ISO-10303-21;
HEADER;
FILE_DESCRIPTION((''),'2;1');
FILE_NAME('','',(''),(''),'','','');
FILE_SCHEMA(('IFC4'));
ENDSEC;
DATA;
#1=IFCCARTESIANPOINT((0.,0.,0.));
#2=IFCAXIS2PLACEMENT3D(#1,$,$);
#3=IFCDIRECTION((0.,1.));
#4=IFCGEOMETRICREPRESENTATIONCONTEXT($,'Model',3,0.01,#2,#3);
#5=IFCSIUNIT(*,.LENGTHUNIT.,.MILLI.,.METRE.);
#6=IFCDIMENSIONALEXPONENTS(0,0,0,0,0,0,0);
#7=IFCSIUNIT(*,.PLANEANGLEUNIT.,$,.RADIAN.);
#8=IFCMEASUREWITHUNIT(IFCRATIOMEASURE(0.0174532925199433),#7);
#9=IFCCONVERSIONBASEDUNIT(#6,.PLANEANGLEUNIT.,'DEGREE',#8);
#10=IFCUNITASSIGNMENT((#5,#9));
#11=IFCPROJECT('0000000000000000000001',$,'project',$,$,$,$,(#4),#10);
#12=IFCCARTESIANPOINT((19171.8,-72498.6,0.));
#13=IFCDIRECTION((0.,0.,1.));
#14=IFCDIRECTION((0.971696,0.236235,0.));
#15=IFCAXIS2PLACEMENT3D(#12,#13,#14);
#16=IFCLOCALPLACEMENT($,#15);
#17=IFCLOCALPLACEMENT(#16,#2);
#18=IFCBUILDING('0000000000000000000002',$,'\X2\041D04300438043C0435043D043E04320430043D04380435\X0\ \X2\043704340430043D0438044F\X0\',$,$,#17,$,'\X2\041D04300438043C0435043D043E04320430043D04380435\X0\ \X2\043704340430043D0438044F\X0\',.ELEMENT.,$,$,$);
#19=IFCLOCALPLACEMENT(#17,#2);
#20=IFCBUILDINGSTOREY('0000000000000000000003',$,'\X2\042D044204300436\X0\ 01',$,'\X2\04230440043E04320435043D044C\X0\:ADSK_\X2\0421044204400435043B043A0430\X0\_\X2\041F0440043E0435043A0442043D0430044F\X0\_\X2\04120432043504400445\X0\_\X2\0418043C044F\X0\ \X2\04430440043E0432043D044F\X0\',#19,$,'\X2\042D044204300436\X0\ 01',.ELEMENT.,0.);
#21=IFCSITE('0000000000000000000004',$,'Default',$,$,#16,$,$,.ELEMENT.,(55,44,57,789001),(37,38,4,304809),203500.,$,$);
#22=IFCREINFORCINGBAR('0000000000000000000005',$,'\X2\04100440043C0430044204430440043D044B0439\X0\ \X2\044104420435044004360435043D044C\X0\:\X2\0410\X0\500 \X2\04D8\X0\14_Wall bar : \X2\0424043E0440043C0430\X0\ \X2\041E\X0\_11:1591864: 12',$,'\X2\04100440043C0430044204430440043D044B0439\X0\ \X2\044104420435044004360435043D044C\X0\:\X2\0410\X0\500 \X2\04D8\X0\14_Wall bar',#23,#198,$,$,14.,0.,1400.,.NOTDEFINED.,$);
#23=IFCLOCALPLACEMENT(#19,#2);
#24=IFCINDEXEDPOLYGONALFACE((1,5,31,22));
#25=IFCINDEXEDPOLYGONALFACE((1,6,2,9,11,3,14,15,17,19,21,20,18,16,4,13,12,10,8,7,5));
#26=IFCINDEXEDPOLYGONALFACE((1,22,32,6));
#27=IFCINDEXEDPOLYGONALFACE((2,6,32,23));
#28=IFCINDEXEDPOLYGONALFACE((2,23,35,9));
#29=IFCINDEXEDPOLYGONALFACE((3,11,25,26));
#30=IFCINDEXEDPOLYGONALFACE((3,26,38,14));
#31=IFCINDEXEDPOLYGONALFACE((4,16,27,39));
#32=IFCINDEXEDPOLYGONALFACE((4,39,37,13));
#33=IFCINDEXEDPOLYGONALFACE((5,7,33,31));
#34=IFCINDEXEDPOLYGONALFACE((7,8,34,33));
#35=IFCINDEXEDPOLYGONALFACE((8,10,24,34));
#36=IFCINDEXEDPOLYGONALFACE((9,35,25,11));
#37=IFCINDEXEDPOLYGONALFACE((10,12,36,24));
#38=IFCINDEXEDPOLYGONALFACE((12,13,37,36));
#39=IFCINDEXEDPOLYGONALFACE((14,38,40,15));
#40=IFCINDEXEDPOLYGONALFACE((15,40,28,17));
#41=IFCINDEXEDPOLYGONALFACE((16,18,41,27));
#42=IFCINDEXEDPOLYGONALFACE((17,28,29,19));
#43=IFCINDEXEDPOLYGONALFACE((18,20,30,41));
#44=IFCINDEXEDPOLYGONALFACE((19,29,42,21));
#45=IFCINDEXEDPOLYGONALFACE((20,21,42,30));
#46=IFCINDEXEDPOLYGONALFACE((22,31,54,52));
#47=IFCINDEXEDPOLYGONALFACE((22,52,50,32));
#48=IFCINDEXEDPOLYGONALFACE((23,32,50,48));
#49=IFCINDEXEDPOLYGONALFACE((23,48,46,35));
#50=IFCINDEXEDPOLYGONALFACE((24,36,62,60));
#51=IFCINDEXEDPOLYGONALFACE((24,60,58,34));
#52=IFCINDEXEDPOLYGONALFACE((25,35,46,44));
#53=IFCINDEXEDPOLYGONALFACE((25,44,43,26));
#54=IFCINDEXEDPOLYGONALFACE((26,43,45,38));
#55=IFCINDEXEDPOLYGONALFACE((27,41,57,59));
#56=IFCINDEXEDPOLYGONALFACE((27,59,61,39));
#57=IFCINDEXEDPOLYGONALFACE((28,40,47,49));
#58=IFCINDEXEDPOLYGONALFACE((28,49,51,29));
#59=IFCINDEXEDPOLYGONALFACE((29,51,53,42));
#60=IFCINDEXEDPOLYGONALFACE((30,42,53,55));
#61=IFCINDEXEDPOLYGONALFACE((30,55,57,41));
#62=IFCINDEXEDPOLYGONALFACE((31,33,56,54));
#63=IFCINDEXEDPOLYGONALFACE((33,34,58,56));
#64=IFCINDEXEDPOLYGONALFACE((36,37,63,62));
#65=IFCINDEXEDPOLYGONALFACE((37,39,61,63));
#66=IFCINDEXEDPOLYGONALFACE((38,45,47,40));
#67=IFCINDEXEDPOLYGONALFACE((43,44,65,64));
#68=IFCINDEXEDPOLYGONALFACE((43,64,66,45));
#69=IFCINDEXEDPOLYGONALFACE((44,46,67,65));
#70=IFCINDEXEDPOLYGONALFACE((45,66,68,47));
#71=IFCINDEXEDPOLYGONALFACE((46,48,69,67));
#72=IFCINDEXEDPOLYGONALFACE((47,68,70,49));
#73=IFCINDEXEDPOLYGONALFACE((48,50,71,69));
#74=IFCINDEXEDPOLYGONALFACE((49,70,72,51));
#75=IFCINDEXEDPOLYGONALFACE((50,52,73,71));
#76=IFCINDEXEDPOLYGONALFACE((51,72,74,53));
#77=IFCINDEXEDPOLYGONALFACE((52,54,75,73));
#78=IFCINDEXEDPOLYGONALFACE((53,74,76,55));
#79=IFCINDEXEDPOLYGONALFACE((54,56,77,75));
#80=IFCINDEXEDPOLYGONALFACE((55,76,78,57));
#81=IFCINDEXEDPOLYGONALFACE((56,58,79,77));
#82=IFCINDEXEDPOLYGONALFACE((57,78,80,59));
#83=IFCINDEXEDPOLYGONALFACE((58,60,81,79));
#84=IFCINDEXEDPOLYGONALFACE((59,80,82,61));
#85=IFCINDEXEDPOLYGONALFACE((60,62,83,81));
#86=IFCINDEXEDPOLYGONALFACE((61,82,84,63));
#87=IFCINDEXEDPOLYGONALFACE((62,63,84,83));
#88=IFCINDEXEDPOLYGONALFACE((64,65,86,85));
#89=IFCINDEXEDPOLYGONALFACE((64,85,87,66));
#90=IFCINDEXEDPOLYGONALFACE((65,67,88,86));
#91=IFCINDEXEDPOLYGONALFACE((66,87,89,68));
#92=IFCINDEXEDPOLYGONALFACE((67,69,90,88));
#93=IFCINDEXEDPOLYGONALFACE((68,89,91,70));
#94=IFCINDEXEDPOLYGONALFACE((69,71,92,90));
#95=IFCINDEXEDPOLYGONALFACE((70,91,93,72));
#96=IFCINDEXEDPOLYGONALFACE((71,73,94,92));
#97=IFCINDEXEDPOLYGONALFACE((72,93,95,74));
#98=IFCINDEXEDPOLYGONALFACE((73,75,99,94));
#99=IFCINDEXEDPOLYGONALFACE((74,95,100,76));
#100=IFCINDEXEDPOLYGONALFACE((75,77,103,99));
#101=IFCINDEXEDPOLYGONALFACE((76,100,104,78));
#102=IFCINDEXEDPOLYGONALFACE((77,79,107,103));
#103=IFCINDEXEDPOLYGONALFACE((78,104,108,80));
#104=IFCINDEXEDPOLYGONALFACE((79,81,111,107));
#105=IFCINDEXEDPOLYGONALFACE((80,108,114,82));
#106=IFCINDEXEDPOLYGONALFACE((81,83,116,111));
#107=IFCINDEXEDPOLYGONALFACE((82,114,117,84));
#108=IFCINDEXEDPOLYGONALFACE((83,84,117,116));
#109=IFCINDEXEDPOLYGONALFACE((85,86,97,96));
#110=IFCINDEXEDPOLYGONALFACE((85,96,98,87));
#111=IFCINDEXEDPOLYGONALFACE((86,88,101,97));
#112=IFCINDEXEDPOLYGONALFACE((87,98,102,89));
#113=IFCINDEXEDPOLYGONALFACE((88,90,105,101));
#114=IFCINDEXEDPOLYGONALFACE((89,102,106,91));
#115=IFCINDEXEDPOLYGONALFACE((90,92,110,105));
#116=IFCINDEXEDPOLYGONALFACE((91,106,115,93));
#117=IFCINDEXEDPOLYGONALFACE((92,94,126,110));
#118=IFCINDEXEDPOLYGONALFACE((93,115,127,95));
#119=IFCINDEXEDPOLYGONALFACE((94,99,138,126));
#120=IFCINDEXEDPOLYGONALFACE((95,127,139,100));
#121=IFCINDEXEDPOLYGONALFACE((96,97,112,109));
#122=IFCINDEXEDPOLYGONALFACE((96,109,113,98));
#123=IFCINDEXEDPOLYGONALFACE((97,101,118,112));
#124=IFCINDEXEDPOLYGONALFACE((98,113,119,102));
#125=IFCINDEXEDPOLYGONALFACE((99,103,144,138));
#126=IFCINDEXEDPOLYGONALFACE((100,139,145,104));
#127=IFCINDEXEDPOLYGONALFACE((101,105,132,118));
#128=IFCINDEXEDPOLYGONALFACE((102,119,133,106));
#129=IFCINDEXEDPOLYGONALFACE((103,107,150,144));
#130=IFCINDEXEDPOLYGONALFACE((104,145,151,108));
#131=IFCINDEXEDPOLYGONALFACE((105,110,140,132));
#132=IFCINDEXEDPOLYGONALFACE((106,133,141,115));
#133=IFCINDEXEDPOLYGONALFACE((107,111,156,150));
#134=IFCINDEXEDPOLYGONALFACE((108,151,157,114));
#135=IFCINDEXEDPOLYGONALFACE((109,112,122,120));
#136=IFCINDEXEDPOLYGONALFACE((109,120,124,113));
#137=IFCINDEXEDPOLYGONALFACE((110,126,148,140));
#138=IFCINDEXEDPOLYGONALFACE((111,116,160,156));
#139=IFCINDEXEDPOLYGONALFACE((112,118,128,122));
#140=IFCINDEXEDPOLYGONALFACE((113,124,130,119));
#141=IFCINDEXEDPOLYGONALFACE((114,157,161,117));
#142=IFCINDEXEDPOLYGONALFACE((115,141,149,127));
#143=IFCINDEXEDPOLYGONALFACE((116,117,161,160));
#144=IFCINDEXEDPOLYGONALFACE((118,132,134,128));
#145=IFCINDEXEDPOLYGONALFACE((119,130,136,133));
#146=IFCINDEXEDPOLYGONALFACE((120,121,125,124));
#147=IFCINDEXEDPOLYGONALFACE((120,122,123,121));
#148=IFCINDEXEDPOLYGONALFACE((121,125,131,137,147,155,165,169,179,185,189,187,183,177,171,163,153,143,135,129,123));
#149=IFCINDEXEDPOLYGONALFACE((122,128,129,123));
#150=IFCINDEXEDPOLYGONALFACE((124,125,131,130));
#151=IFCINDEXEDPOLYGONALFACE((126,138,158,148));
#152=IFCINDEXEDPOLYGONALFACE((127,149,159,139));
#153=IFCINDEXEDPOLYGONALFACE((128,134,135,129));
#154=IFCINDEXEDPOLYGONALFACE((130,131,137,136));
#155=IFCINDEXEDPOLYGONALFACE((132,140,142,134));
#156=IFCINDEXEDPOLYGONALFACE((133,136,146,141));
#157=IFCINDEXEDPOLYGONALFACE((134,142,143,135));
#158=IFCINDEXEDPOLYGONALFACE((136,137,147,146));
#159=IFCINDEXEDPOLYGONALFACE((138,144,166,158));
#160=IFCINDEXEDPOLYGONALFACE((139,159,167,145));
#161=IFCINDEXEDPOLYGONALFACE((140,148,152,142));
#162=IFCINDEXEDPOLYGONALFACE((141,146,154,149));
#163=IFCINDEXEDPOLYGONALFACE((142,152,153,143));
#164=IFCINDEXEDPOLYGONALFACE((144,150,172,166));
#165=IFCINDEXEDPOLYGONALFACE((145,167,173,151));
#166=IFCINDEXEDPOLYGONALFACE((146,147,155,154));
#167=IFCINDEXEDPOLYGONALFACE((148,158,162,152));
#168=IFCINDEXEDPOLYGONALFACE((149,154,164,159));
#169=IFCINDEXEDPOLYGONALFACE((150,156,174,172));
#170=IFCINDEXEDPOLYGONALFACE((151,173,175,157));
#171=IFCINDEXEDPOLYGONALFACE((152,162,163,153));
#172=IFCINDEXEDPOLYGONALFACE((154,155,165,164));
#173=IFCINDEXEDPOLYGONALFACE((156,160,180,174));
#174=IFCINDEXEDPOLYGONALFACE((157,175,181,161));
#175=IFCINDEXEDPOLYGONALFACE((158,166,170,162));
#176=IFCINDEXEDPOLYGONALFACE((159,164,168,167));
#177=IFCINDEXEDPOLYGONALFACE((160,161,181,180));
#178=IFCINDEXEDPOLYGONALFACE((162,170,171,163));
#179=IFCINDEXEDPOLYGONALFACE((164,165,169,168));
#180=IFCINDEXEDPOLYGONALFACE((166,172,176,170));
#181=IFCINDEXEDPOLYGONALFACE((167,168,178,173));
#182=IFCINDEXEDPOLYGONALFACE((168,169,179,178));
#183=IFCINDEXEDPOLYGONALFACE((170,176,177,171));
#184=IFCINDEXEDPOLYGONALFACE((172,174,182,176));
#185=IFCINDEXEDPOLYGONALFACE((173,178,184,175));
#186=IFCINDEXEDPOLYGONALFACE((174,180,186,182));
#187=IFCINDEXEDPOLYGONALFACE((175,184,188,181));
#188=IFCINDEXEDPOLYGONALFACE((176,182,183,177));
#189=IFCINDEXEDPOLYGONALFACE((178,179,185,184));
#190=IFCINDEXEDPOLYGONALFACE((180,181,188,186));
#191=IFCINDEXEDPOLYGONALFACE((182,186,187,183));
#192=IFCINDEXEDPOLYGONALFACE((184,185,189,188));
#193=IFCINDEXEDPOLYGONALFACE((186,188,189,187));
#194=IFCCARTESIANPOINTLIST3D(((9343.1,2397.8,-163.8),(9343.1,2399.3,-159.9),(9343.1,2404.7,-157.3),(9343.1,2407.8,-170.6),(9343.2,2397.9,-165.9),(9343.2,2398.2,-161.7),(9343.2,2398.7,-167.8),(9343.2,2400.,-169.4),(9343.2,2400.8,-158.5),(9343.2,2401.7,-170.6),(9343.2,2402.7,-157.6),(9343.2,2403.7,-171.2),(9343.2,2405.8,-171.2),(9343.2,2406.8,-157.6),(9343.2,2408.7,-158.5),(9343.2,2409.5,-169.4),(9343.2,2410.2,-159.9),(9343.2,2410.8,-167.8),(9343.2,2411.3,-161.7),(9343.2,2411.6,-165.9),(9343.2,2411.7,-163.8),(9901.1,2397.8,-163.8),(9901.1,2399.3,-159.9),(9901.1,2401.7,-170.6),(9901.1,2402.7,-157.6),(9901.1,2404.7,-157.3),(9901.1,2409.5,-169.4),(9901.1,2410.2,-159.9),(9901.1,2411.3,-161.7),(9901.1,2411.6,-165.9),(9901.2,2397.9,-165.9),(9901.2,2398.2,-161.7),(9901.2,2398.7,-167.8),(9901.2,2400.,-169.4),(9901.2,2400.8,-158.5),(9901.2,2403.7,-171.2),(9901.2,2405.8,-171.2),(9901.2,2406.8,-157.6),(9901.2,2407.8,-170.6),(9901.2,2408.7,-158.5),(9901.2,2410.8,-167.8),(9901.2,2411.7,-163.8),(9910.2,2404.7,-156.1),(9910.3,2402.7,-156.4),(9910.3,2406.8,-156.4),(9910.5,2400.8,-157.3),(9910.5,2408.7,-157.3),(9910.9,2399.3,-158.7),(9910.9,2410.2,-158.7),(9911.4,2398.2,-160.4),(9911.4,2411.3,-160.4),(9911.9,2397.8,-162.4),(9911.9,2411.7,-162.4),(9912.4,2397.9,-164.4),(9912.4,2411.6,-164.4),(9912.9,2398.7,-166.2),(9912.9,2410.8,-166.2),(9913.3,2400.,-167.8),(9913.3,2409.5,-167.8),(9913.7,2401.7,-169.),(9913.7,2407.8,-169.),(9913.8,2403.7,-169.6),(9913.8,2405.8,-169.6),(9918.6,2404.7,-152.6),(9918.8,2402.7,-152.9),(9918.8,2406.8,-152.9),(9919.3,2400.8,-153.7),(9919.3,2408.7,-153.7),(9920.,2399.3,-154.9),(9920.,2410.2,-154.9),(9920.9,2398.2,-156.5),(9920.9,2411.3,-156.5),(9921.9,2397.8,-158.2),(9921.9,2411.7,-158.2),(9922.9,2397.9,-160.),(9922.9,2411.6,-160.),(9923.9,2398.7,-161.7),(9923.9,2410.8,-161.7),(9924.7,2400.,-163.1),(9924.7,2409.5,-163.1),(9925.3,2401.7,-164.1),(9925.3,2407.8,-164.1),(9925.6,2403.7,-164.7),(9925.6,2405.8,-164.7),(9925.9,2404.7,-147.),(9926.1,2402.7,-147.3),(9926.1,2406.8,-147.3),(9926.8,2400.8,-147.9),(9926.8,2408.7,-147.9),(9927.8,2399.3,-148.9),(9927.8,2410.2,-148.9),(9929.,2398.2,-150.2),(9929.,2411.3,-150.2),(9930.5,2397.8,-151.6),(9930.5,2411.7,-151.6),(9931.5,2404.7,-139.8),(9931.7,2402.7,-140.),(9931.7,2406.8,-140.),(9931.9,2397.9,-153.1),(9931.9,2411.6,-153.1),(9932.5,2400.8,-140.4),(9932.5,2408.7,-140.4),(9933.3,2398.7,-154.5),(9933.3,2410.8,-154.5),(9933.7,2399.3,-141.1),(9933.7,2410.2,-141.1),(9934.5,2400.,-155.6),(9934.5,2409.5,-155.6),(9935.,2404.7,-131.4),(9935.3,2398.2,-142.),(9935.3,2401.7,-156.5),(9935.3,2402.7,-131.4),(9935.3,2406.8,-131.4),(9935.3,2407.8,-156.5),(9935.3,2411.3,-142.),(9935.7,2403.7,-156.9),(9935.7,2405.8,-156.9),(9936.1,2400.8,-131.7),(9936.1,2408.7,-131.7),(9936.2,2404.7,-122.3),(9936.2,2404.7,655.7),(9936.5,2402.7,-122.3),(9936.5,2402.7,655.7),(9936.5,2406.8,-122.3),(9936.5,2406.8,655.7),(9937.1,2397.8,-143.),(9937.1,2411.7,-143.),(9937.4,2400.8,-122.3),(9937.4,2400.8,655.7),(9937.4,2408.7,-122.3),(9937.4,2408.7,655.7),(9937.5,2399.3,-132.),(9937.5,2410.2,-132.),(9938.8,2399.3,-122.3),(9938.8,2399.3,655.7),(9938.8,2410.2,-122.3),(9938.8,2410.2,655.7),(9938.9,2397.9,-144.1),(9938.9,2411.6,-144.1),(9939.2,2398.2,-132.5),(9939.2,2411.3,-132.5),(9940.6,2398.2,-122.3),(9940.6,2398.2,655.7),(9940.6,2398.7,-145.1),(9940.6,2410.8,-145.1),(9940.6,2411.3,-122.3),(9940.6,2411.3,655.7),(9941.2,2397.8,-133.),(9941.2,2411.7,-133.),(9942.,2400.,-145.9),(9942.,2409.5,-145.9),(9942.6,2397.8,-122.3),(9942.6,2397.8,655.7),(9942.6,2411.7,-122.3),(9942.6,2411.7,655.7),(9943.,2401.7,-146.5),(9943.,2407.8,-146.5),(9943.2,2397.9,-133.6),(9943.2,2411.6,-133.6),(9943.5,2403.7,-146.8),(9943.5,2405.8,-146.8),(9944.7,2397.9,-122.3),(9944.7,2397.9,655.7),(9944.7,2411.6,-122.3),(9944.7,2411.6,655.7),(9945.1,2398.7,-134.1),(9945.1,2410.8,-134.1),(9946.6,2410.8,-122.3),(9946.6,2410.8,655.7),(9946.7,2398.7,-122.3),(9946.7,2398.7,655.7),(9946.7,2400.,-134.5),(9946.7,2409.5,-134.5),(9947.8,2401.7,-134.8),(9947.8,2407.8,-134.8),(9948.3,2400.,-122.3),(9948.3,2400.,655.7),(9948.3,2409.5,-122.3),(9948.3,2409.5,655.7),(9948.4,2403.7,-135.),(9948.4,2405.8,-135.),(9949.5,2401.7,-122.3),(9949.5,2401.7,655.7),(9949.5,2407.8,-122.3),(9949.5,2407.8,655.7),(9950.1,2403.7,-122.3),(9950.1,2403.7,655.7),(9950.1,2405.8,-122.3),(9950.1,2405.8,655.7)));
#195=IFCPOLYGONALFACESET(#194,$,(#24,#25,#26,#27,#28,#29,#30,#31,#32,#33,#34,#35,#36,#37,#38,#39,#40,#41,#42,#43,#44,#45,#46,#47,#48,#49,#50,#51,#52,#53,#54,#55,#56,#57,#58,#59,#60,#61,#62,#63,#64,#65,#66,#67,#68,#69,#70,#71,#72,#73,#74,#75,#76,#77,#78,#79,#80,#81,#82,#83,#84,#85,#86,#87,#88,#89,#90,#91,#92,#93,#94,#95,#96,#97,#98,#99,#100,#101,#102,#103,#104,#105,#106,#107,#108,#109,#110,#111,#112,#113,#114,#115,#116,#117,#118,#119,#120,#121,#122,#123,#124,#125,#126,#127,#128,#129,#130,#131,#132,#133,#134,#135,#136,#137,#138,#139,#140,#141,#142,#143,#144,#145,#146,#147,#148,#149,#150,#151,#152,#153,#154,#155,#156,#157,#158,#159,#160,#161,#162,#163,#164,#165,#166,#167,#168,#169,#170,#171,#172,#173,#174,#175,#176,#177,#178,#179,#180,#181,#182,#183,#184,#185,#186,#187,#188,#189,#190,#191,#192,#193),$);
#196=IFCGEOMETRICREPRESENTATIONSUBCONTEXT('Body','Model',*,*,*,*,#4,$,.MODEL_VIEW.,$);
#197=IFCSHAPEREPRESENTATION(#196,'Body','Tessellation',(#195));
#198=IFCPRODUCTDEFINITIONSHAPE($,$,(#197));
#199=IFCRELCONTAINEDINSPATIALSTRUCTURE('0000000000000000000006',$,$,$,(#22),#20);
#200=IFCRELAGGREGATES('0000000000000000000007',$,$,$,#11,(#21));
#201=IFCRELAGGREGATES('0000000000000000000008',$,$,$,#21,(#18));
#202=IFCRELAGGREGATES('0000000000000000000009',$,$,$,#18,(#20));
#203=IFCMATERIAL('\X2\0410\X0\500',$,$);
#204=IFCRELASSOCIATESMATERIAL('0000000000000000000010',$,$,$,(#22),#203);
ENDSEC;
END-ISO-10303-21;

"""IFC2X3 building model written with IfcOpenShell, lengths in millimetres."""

from ifc_helpers import new_model, entity, si_unit, converted_unit, direction, frame, origin, place, context, subcontext, project, spatial, material, element, save


model = new_model("IFC2X3")

# Units and contexts
model_context = context("Model", 3, precision=0.01, world=origin(), true_north=direction((0.0, 1.0)))
body_context = subcontext(model_context, "Body", "Model", "MODEL_VIEW")
ifc_project = project(units=[si_unit("LENGTHUNIT", "METRE", prefix="MILLI"), converted_unit("PLANEANGLEUNIT", "DEGREE", entity("IfcRatioMeasure", 0.0174532925199433), si_unit("PLANEANGLEUNIT", "RADIAN"), dimensions=[0, 0, 0, 0, 0, 0, 0])], contexts=[model_context])

# Site, building, storey
site_placement = place(None, frame((19171.8, -72498.6, 0.0), z_axis=(0.0, 0.0, 1.0), x_axis=(0.971696, 0.236235, 0.0)))
site = spatial("IfcSite", under=ifc_project, at=site_placement, Name="Default", CompositionType="ELEMENT", RefLatitude=(55, 44, 57, 789001), RefLongitude=(37, 38, 4, 304809), RefElevation=203500.0)
building_placement = place(site_placement, origin())
building = spatial("IfcBuilding", under=site, at=building_placement, Name="Наименование здания", LongName="Наименование здания", CompositionType="ELEMENT")
storey_placement = place(building_placement, origin())
storey = spatial("IfcBuildingStorey", under=building, at=storey_placement, Name="Этаж 01", ObjectType="Уровень:ADSK_Стрелка_Проектная_Вверх_Имя уровня", LongName="Этаж 01", CompositionType="ELEMENT", Elevation=0.0)

# Reinforcing bar
ifc_material = material(Name="А500")
placement = place(storey_placement, origin())
element("IfcReinforcingBar", 1, at=placement, inside=storey, material=ifc_material, Name="Арматурный стержень:А500 Ә14_Wall bar : Форма О_11:1591864: 12", ObjectType="Арматурный стержень:А500 Ә14_Wall bar", BarLength=1400.0, BarRole="NOTDEFINED", CrossSectionArea=0.0, NominalDiameter=14.0, context=body_context, shape_type="AdvancedSweptSolid", body=[
    entity("IfcSweptDiskSolid", entity("IfcCompositeCurve", [entity("IfcCompositeCurveSegment", "CONTINUOUS", True, entity("IfcPolyline", [entity("IfcCartesianPoint", [9943.1, 2404.7, 655.7]), entity("IfcCartesianPoint", [9943.1, 2404.7, -122.3])])), entity("IfcCompositeCurveSegment", "CONTINUOUS", True, entity("IfcTrimmedCurve", entity("IfcCircle", entity("IfcAxis2Placement3D", entity("IfcCartesianPoint", [9901.1, 2404.7, -122.3]), entity("IfcDirection", [0.0, 1.0, 0.0]), entity("IfcDirection", [0.0, 0.0, -1.0])), 42.0), [entity("IfcParameterValue", 270.0)], [entity("IfcParameterValue", 360.0)], True, "PARAMETER")), entity("IfcCompositeCurveSegment", "CONTINUOUS", True, entity("IfcPolyline", [entity("IfcCartesianPoint", [9901.1, 2404.7, -164.3]), entity("IfcCartesianPoint", [9343.1, 2404.7, -164.3])]))], False), 7.0, None, 0.0, 92.0),
])

save(model, "model.ifc")
